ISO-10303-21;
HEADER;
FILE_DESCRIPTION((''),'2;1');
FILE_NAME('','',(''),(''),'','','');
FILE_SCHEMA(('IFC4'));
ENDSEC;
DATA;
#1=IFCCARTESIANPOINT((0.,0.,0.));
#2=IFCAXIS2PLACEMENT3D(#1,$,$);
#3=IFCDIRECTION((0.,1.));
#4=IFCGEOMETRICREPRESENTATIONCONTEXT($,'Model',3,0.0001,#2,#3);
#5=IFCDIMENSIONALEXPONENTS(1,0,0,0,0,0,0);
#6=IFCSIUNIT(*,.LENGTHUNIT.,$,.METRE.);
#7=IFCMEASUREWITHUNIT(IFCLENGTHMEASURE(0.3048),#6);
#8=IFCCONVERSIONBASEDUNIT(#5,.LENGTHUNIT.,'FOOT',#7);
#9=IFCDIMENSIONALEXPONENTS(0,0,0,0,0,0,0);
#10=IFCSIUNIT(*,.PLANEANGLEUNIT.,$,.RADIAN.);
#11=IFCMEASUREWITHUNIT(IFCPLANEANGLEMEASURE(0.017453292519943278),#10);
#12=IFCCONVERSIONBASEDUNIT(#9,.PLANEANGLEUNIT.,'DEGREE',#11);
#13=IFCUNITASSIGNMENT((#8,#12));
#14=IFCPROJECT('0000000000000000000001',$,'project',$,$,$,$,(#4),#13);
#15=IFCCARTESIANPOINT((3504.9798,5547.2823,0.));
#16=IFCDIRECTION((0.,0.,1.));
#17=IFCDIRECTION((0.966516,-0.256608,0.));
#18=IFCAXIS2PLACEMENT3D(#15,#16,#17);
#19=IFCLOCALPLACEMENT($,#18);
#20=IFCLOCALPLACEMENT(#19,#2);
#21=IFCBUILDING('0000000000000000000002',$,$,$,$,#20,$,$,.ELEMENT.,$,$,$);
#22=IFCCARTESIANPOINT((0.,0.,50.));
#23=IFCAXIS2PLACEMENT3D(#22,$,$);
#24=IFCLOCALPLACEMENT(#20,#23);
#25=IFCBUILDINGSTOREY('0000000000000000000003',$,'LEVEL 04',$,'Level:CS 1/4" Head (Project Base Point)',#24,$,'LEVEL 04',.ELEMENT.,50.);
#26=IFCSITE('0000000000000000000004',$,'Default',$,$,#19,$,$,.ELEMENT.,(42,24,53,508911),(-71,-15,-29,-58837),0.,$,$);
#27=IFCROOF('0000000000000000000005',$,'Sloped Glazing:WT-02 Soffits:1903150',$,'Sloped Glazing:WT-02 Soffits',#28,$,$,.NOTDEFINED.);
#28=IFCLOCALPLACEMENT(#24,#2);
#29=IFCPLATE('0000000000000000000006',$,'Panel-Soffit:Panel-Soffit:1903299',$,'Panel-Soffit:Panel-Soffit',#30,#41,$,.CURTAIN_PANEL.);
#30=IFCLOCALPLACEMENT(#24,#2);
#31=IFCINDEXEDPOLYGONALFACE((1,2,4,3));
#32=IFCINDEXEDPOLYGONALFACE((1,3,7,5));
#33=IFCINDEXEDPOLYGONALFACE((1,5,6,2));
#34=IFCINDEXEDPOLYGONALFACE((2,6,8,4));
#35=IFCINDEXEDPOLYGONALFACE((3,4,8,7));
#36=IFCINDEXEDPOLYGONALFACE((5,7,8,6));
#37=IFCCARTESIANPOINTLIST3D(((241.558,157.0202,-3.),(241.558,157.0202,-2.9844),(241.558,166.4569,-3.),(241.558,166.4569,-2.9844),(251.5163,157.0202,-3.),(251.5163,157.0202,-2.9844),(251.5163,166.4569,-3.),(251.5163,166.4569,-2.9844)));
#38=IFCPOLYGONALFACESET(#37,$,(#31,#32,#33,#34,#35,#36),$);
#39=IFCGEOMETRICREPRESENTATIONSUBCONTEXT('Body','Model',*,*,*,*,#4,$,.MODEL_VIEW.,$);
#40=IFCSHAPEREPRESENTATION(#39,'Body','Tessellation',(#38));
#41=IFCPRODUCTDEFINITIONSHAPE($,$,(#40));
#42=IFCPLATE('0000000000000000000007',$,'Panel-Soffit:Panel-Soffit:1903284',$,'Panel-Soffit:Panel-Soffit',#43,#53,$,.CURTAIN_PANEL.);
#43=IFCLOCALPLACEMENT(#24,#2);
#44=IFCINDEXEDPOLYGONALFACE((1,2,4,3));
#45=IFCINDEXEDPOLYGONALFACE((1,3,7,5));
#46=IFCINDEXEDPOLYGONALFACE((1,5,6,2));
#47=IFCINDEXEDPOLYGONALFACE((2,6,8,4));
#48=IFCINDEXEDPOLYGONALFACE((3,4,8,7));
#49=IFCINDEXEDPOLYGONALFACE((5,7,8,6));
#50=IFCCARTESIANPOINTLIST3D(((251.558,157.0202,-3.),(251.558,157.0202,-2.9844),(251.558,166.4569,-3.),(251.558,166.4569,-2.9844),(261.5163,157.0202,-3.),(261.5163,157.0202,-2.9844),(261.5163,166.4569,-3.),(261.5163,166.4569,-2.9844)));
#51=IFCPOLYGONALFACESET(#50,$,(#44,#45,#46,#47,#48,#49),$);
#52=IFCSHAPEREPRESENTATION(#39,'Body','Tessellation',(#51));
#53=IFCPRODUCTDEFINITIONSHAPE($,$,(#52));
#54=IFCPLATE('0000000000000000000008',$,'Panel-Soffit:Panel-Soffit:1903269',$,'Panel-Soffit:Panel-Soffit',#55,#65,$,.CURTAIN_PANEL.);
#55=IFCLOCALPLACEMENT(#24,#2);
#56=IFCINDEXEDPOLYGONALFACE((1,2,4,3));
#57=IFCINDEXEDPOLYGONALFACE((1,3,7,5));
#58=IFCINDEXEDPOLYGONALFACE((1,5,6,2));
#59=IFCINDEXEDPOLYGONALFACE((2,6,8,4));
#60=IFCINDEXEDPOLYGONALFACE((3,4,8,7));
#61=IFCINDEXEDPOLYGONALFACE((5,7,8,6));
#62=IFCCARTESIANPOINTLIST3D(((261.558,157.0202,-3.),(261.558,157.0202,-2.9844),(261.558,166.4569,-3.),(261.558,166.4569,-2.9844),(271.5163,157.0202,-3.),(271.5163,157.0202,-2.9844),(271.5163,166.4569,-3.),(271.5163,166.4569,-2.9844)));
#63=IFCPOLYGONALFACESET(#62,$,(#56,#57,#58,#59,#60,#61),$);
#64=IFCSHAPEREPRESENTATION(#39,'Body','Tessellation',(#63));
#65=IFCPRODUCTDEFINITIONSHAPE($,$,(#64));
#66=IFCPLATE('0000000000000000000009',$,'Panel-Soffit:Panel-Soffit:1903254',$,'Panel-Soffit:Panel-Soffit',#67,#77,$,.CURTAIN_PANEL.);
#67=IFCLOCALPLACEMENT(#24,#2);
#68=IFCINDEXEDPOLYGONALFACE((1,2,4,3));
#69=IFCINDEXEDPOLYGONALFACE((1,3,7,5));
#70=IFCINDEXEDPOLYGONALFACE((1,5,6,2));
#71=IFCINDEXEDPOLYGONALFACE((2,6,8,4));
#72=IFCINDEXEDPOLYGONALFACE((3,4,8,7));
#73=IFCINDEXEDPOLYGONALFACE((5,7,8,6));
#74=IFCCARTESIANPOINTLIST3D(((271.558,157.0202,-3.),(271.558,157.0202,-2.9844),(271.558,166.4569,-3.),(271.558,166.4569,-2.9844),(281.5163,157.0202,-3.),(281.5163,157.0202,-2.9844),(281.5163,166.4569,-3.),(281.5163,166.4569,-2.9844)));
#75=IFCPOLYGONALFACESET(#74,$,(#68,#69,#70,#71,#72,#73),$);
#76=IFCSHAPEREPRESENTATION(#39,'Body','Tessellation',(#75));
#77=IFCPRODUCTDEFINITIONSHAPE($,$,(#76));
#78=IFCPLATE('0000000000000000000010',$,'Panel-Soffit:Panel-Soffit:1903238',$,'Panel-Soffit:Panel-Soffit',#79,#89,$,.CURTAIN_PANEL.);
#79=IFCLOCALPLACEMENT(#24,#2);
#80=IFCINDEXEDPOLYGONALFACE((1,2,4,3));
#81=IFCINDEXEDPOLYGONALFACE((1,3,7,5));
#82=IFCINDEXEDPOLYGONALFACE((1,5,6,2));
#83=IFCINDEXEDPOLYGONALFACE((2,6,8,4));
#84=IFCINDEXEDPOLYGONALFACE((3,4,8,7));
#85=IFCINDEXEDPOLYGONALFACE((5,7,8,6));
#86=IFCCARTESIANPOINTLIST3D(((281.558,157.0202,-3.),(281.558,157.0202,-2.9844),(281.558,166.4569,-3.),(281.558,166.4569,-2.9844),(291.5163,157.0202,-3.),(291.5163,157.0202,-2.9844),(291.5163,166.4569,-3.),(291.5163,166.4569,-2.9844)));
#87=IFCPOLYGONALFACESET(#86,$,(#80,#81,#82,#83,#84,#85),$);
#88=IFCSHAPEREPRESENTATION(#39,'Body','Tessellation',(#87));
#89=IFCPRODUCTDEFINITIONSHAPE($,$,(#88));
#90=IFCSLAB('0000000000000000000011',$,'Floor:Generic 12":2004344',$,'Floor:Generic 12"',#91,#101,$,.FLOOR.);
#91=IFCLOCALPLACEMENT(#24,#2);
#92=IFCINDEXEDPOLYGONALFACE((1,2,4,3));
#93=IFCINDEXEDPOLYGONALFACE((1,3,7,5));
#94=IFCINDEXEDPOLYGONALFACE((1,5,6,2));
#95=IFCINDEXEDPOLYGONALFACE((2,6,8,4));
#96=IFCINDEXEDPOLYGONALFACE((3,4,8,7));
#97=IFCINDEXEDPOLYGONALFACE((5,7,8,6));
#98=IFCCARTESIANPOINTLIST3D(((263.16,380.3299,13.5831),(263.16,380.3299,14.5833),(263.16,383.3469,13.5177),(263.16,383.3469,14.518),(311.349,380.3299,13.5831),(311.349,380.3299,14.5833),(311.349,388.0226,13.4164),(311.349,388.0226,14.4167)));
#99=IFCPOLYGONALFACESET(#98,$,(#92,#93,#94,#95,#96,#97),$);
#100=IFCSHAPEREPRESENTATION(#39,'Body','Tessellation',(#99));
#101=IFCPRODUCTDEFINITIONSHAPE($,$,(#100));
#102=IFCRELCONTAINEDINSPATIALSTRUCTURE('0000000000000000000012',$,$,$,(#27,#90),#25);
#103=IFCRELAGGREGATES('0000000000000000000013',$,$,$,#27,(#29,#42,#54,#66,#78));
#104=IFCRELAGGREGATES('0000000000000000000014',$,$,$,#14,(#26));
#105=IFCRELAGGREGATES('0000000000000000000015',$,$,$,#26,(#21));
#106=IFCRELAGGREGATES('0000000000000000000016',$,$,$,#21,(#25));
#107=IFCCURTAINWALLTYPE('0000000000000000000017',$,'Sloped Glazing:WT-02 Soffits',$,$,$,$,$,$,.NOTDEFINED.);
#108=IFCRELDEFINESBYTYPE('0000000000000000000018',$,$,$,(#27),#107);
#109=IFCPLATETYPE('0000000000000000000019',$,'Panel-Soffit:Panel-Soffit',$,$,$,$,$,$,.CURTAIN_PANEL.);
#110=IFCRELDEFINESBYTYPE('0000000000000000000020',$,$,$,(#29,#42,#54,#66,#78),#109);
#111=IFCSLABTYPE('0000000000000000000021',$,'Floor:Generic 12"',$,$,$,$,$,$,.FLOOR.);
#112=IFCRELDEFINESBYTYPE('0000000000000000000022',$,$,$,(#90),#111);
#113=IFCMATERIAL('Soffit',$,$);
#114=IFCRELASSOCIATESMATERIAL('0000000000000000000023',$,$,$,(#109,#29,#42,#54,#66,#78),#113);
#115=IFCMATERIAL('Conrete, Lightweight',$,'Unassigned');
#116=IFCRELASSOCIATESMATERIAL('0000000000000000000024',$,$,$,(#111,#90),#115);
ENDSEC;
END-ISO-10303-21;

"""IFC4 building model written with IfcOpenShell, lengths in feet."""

from ifc_helpers import new_model, entity, si_unit, converted_unit, direction, frame, origin, place, context, subcontext, project, spatial, polyline, indexed_curve, outline, extrude, source, transform, mapped, material, type_object, type_shapes, element, aggregate, save


model = new_model("IFC4")

# Units and contexts
model_context = context("Model", 3, precision=0.0001, world=origin(), true_north=direction((0.0, 1.0)))
body_context = subcontext(model_context, "Body", "Model", "MODEL_VIEW")
ifc_project = project(units=[converted_unit("LENGTHUNIT", "FOOT", entity("IfcLengthMeasure", 0.3048), si_unit("LENGTHUNIT", "METRE"), dimensions=[1, 0, 0, 0, 0, 0, 0]), converted_unit("PLANEANGLEUNIT", "DEGREE", entity("IfcPlaneAngleMeasure", 0.017453292519943278), si_unit("PLANEANGLEUNIT", "RADIAN"), dimensions=[0, 0, 0, 0, 0, 0, 0])], contexts=[model_context])

# Site, building, storey
site_placement = place(None, frame((3504.9798, 5547.2823, 0.0), z_axis=(0.0, 0.0, 1.0), x_axis=(0.966516, -0.256608, 0.0)))
site = spatial("IfcSite", under=ifc_project, at=site_placement, Name="Default", CompositionType="ELEMENT", RefLatitude=(42, 24, 53, 508911), RefLongitude=(-71, -15, -29, -58837), RefElevation=0.0)
building_placement = place(site_placement, origin())
building = spatial("IfcBuilding", under=site, at=building_placement, CompositionType="ELEMENT")
storey_placement = place(building_placement, frame((0.0, 0.0, 50.0)))
storey = spatial("IfcBuildingStorey", under=building, at=storey_placement, Name="LEVEL 04", ObjectType="Level:CS 1/4\" Head (Project Base Point)", LongName="LEVEL 04", CompositionType="ELEMENT", Elevation=50.0)

# Roof, plates
curtain_wall_type_1 = type_object("IfcCurtainWallType", Name="Sloped Glazing:WT-02 Soffits", PredefinedType="NOTDEFINED")
roof_placement = place(storey_placement, frame((0.0, 0.0, -50.0)))
roof = element("IfcRoof", 1, at=roof_placement, inside=storey, type_object=curtain_wall_type_1, Name="Sloped Glazing:WT-02 Soffits:1903150", ObjectType="Sloped Glazing:WT-02 Soffits", PredefinedType="NOTDEFINED")
ifc_material_1 = material(Name="Soffit")
plate_type_1 = type_object("IfcPlateType", Name="Panel-Soffit:Panel-Soffit", PredefinedType="CURTAIN_PANEL", material=ifc_material_1)
shared_shape_1 = source(origin(), body_context, "Body", "SweptSolid", [
    extrude(outline(indexed_curve([(-0.0078, -4.9792), (0.0078, -4.9792), (0.0078, 4.9792), (-0.0078, 4.9792), (-0.0078, -4.9792)], self_intersect=False)), frame((4.9792, 0.0078, 0.0), z_axis=(0.0, 0.0, 1.0), x_axis=(0.0, -1.0, 0.0)), (0.0, 0.0, 1.0), 9.4367),
])
type_shapes(plate_type_1, [shared_shape_1])
plate_1_placement = place(roof_placement, frame((241.558, 157.0202, 47.0156), z_axis=(0.0, 1.0, 0.0), x_axis=(1.0, 0.0, 0.0)))
plate_1 = element("IfcPlate", 2, at=plate_1_placement, type_object=plate_type_1, material=ifc_material_1, Name="Panel-Soffit:Panel-Soffit:1903299", ObjectType="Panel-Soffit:Panel-Soffit", PredefinedType="CURTAIN_PANEL", context=body_context, shape_type="MappedRepresentation", body=[
    mapped(shared_shape_1, transform((0.0, 0.0, 0.0), scale=1.0)),
])
plate_2_placement = place(roof_placement, frame((251.558, 157.0202, 47.0156), z_axis=(0.0, 1.0, 0.0), x_axis=(1.0, 0.0, 0.0)))
plate_2 = element("IfcPlate", 3, at=plate_2_placement, type_object=plate_type_1, material=ifc_material_1, Name="Panel-Soffit:Panel-Soffit:1903284", ObjectType="Panel-Soffit:Panel-Soffit", PredefinedType="CURTAIN_PANEL", context=body_context, shape_type="MappedRepresentation", body=[
    mapped(shared_shape_1, transform((0.0, 0.0, 0.0), scale=1.0)),
])
plate_3_placement = place(roof_placement, frame((261.558, 157.0202, 47.0156), z_axis=(0.0, 1.0, 0.0), x_axis=(1.0, 0.0, 0.0)))
plate_3 = element("IfcPlate", 4, at=plate_3_placement, type_object=plate_type_1, material=ifc_material_1, Name="Panel-Soffit:Panel-Soffit:1903269", ObjectType="Panel-Soffit:Panel-Soffit", PredefinedType="CURTAIN_PANEL", context=body_context, shape_type="MappedRepresentation", body=[
    mapped(shared_shape_1, transform((0.0, 0.0, 0.0), scale=1.0)),
])
plate_4_placement = place(roof_placement, frame((271.558, 157.0202, 47.0156), z_axis=(0.0, 1.0, 0.0), x_axis=(1.0, 0.0, 0.0)))
plate_4 = element("IfcPlate", 5, at=plate_4_placement, type_object=plate_type_1, material=ifc_material_1, Name="Panel-Soffit:Panel-Soffit:1903254", ObjectType="Panel-Soffit:Panel-Soffit", PredefinedType="CURTAIN_PANEL", context=body_context, shape_type="MappedRepresentation", body=[
    mapped(shared_shape_1, transform((0.0, 0.0, 0.0), scale=1.0)),
])
plate_5_placement = place(roof_placement, frame((281.558, 157.0202, 47.0156), z_axis=(0.0, 1.0, 0.0), x_axis=(1.0, 0.0, 0.0)))
plate_5 = element("IfcPlate", 6, at=plate_5_placement, type_object=plate_type_1, material=ifc_material_1, Name="Panel-Soffit:Panel-Soffit:1903238", ObjectType="Panel-Soffit:Panel-Soffit", PredefinedType="CURTAIN_PANEL", context=body_context, shape_type="MappedRepresentation", body=[
    mapped(shared_shape_1, transform((0.0, 0.0, 0.0), scale=1.0)),
])
aggregate(roof, [plate_1, plate_2, plate_3, plate_4, plate_5])

# Slab
ifc_material_2 = material(Name="Conrete, Lightweight", Category="Unassigned")
slab_type = type_object("IfcSlabType", Name="Floor:Generic 12\"", PredefinedType="FLOOR", material=ifc_material_2)
slab_1_placement = place(storey_placement, frame((263.16, 380.3299, 13.4164)))
element("IfcSlab", 7, at=slab_1_placement, inside=storey, type_object=slab_type, material=ifc_material_2, Name="Floor:Generic 12\":2004344", ObjectType="Floor:Generic 12\"", PredefinedType="FLOOR", context=body_context, shape_type="SweptSolid", body=[
    extrude(outline(polyline([(24.0945, 7.6945), (-24.0945, 3.0177), (-24.0945, 0.0), (24.0945, 0.0), (24.0945, 7.6945)])), frame((24.0945, 0.0, 1.1669), z_axis=(0.0, 0.021661, 0.999765), x_axis=(1.0, 0.0, 0.0)), (0.0, 0.021661, -0.999765), 1.0002),
])

save(model, "model.ifc")
